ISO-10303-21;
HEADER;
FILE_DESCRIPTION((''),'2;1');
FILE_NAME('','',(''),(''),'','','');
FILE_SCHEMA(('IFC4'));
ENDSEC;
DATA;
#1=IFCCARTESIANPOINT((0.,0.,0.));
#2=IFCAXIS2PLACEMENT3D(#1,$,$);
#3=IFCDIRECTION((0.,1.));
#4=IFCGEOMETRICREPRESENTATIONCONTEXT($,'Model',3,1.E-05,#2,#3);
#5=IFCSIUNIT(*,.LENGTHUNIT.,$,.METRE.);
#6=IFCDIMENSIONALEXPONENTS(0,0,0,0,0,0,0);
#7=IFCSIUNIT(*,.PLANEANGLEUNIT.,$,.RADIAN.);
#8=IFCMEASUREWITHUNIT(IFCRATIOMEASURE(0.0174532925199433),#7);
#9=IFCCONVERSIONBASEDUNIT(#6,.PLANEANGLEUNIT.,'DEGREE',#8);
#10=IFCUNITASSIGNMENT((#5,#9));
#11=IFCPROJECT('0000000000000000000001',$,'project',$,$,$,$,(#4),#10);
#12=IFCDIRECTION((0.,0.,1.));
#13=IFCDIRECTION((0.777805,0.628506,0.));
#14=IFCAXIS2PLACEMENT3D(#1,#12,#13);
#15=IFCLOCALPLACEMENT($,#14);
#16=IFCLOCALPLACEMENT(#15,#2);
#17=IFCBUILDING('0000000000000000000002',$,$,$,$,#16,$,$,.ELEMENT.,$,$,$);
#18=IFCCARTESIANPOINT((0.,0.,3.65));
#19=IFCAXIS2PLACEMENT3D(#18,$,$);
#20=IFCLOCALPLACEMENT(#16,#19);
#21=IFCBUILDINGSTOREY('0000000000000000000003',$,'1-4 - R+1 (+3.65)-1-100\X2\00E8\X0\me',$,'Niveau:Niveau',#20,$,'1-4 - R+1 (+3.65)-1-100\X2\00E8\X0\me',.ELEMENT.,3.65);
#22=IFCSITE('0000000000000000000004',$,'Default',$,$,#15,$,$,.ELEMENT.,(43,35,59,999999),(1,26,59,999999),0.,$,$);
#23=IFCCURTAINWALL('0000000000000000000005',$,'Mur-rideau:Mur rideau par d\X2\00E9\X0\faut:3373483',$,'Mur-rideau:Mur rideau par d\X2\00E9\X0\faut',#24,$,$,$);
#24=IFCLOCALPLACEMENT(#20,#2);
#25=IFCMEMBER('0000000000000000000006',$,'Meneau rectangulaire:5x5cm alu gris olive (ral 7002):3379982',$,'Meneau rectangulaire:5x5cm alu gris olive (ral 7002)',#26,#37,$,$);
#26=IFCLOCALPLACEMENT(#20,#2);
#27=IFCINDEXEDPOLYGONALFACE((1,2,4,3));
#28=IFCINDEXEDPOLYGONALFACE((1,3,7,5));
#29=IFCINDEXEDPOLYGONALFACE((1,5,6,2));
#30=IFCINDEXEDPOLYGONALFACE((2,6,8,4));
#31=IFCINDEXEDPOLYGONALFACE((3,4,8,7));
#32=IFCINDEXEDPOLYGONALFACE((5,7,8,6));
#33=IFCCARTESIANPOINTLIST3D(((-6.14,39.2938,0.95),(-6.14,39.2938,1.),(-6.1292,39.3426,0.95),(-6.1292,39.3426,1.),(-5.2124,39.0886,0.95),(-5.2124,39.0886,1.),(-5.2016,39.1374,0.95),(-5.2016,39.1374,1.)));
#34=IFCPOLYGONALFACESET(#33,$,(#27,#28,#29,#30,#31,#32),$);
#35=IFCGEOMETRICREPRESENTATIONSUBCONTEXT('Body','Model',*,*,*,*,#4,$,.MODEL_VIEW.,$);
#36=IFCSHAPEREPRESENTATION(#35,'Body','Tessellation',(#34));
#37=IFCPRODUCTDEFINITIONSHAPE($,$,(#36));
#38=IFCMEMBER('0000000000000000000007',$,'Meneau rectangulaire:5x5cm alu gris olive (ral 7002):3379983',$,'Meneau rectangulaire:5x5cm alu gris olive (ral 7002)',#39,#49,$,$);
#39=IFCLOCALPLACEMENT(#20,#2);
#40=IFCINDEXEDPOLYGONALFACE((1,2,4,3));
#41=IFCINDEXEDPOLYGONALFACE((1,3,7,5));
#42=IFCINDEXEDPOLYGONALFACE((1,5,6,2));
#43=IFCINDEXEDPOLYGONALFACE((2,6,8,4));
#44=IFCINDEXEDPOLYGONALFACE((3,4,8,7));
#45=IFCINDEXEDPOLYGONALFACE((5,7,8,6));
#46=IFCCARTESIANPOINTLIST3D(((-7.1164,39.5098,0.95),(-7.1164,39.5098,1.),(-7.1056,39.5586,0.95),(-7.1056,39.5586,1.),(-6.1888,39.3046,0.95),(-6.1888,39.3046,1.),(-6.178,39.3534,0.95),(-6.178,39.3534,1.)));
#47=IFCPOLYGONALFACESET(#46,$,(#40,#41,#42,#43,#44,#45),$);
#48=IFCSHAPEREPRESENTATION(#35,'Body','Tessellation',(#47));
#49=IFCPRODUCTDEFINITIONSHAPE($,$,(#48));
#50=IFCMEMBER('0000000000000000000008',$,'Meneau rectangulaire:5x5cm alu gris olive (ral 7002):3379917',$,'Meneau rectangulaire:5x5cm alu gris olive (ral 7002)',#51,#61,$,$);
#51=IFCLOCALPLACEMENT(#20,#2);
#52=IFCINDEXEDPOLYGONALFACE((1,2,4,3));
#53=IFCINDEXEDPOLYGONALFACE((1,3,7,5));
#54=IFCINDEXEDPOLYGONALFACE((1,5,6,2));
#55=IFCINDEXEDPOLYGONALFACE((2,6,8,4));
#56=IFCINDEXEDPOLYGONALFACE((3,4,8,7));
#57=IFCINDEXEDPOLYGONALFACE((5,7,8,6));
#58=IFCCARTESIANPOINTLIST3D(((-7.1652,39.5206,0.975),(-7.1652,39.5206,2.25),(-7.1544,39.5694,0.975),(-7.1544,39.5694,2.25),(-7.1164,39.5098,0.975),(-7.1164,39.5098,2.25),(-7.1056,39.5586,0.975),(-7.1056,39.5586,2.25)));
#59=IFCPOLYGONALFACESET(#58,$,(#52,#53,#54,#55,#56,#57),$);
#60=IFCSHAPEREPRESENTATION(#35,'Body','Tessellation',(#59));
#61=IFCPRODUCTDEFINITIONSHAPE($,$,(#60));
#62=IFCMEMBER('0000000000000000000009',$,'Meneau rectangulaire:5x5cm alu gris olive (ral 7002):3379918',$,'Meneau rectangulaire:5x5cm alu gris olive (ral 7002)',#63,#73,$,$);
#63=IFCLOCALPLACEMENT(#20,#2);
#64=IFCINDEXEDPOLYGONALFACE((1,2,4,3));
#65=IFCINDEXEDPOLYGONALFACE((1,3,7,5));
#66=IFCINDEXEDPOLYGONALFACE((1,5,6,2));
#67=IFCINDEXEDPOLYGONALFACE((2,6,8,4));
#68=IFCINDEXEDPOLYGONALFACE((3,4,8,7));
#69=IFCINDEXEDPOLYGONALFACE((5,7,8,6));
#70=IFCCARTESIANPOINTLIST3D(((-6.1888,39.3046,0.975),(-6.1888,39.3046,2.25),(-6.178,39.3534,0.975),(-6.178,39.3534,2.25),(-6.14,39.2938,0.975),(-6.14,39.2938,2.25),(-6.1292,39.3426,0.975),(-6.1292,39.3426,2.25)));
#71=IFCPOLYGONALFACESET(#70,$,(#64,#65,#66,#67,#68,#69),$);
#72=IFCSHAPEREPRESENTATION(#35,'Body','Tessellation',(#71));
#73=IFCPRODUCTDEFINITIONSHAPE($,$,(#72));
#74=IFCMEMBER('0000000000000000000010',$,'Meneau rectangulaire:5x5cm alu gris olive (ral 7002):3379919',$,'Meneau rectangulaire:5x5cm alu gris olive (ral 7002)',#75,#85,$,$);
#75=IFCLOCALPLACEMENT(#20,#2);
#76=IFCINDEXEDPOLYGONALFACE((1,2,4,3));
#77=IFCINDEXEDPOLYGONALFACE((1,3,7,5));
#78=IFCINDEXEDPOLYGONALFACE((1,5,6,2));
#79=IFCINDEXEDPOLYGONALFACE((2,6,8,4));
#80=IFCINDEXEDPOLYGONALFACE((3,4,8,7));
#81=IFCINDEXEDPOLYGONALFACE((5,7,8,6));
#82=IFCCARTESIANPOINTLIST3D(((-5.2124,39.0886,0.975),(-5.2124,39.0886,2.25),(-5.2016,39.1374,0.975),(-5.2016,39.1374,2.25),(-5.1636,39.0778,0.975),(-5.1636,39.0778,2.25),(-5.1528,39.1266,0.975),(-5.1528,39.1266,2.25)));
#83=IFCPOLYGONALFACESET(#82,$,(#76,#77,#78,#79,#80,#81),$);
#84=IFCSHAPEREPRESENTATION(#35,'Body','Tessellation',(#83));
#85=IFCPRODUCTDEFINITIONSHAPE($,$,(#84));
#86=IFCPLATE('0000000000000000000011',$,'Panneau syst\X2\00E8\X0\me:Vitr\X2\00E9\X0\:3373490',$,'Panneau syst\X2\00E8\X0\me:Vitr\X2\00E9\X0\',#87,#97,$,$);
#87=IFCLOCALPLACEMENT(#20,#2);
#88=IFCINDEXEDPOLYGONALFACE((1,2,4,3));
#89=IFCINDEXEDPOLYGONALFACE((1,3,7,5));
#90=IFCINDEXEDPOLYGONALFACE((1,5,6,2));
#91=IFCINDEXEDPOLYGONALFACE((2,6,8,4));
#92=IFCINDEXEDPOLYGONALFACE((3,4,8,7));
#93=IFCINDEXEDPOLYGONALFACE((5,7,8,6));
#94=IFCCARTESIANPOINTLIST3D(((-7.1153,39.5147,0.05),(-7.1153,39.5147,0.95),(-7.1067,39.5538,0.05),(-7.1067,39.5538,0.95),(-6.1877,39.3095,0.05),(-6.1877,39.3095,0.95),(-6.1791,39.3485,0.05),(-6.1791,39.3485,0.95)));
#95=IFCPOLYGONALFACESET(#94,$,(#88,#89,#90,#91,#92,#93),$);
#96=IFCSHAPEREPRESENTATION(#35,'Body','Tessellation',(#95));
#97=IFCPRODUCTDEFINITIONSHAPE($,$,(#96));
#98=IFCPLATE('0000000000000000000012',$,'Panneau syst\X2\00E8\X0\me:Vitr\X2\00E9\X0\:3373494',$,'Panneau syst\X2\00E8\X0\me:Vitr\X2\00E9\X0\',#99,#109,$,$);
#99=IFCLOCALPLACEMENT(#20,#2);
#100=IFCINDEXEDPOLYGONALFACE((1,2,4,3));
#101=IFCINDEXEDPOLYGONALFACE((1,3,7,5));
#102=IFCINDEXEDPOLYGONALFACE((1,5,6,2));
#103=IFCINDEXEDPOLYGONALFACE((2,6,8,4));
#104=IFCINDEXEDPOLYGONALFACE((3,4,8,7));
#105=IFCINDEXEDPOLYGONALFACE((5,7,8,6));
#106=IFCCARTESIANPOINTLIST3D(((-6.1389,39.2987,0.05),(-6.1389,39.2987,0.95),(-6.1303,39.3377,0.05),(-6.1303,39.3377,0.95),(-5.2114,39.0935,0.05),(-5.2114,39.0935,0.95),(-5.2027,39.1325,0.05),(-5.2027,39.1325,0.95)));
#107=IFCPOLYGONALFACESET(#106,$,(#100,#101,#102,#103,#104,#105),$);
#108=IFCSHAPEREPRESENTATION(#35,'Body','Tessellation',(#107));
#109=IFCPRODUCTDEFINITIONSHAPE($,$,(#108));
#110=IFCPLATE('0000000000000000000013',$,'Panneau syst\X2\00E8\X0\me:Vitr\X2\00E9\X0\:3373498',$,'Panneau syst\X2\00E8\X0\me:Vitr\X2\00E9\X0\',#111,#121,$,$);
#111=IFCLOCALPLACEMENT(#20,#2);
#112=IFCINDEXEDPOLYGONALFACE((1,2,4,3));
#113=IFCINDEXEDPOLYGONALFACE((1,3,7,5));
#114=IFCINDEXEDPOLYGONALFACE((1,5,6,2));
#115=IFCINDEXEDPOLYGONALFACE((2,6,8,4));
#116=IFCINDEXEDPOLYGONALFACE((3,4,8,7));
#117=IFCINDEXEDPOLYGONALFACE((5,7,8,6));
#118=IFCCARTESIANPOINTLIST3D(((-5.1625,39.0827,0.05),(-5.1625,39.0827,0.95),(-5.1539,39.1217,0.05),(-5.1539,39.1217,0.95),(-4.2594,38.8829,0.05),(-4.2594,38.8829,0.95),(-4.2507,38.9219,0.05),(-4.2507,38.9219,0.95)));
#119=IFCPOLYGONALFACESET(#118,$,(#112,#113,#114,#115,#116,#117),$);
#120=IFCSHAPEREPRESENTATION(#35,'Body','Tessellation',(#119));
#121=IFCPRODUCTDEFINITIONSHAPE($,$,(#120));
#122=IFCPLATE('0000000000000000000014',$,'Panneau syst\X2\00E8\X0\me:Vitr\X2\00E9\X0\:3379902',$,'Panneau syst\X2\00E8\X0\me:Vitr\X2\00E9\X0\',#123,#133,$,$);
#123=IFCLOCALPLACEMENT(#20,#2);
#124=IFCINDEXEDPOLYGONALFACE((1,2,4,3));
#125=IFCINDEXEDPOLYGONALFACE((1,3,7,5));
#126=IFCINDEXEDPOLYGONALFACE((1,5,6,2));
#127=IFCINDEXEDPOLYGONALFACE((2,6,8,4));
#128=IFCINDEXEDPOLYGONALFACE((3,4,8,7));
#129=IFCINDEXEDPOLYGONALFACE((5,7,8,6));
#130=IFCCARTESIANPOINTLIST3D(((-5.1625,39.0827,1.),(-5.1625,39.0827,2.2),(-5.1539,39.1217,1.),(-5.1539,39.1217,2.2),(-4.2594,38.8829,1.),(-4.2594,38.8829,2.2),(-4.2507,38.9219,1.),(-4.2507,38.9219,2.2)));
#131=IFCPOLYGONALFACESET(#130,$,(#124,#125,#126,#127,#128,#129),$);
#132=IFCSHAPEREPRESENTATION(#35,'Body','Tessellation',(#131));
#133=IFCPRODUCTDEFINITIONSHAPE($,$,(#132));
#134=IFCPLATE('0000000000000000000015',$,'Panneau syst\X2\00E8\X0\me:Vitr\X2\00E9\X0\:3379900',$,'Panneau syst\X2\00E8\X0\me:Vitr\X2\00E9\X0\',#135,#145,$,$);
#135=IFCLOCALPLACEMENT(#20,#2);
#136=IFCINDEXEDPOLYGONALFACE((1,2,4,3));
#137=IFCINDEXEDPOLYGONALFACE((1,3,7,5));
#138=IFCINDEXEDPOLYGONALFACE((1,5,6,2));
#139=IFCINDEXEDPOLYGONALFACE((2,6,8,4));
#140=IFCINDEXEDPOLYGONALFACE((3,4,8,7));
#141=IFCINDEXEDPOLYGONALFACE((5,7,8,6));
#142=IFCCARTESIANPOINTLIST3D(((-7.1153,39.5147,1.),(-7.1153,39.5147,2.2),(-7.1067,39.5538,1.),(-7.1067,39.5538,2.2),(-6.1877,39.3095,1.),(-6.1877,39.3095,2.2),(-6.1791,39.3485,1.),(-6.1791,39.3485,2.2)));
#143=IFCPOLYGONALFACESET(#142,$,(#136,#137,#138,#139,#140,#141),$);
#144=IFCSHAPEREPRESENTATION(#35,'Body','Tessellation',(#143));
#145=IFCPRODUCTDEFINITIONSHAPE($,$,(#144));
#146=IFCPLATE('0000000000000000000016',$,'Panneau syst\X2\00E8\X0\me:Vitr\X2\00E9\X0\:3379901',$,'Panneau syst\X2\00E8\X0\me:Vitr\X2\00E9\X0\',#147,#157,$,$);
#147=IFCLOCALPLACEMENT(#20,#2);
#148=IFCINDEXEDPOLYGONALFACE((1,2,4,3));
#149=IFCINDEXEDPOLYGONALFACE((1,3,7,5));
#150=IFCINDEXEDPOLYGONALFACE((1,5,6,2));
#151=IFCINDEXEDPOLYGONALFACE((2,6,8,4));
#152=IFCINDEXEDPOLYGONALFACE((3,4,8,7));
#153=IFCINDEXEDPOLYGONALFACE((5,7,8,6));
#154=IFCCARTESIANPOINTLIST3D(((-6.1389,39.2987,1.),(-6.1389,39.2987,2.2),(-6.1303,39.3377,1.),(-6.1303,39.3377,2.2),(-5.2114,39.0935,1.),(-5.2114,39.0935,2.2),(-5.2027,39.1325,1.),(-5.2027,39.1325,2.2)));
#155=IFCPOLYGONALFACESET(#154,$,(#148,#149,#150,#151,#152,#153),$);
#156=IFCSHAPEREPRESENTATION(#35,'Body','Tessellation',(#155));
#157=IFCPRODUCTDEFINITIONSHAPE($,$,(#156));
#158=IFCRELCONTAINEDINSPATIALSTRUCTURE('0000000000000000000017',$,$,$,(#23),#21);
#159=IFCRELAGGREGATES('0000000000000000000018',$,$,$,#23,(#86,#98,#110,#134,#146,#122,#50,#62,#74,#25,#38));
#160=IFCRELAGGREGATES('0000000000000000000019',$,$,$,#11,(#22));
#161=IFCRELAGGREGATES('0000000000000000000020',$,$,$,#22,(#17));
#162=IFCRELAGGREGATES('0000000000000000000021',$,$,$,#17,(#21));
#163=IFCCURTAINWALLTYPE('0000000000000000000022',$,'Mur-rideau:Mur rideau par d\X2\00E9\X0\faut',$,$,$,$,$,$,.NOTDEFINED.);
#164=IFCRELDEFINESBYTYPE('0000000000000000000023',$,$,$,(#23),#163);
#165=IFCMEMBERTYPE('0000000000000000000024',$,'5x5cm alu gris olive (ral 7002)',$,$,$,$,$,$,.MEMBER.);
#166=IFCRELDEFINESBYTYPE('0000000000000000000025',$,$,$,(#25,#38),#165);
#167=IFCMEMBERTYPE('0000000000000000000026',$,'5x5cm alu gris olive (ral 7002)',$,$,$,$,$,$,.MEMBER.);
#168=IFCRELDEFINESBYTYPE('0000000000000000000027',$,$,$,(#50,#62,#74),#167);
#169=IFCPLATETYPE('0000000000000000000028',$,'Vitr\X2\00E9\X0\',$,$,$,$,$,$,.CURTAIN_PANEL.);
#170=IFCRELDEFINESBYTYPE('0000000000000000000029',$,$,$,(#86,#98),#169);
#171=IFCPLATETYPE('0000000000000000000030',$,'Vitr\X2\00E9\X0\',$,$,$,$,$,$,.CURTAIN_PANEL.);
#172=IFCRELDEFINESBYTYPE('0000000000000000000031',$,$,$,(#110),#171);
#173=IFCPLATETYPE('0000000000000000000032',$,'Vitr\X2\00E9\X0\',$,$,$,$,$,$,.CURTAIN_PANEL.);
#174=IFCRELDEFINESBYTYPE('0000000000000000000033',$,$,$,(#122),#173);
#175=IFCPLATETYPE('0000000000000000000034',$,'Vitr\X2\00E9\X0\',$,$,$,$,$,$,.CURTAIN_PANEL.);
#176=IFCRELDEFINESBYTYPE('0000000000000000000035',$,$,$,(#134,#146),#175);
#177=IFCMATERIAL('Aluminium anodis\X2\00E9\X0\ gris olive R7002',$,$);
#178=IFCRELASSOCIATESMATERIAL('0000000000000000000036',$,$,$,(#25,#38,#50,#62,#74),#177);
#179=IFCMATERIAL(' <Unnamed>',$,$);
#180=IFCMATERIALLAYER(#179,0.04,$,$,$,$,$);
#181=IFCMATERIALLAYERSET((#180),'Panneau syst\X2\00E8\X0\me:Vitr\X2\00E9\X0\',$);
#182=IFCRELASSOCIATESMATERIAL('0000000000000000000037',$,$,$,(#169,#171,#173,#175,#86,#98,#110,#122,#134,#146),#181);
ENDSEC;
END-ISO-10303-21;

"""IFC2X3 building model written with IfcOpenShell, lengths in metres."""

from ifc_helpers import new_model, entity, si_unit, converted_unit, direction, frame, frame_2d, origin, origin_2d_with_axis, place, context, subcontext, project, spatial, rectangle, extrude, source, transform, mapped, material, layer, layer_set, layer_usage, type_object, type_shapes, element, aggregate, save


model = new_model("IFC2X3")

# Units and contexts
model_context = context("Model", 3, precision=1e-05, world=origin(), true_north=direction((0.0, 1.0)))
body_context = subcontext(model_context, "Body", "Model", "MODEL_VIEW")
ifc_project = project(units=[si_unit("LENGTHUNIT", "METRE"), converted_unit("PLANEANGLEUNIT", "DEGREE", entity("IfcRatioMeasure", 0.0174532925199433), si_unit("PLANEANGLEUNIT", "RADIAN"), dimensions=[0, 0, 0, 0, 0, 0, 0])], contexts=[model_context])

# Site, building, storey
site_placement = place(None, frame((0.0, 0.0, 0.0), z_axis=(0.0, 0.0, 1.0), x_axis=(0.777805, 0.628506, 0.0)))
site = spatial("IfcSite", under=ifc_project, at=site_placement, Name="Default", CompositionType="ELEMENT", RefLatitude=(43, 35, 59, 999999), RefLongitude=(1, 26, 59, 999999), RefElevation=0.0)
building_placement = place(site_placement, origin())
building = spatial("IfcBuilding", under=site, at=building_placement, CompositionType="ELEMENT")
storey_placement = place(building_placement, frame((0.0, 0.0, 3.65)))
storey = spatial("IfcBuildingStorey", under=building, at=storey_placement, Name="1-4 - R+1 (+3.65)-1-100ème", ObjectType="Niveau:Niveau", LongName="1-4 - R+1 (+3.65)-1-100ème", CompositionType="ELEMENT", Elevation=3.65)

# Curtain wall, members, plates
curtain_wall_type = type_object("IfcCurtainWallType", Name="Mur-rideau:Mur rideau par défaut", PredefinedType="NOTDEFINED")
curtain_wall_placement = place(storey_placement, frame((0.0, 0.0, -3.65)))
curtain_wall = element("IfcCurtainWall", 1, at=curtain_wall_placement, inside=storey, type_object=curtain_wall_type, Name="Mur-rideau:Mur rideau par défaut:3373483", ObjectType="Mur-rideau:Mur rideau par défaut")
ifc_material_1 = material(Name="Aluminium anodisé gris olive R7002")
member_type_1 = type_object("IfcMemberType", Name="5x5cm alu gris olive (ral 7002)", PredefinedType="MEMBER")
shared_shape_1 = source(origin(), body_context, "Body", "SweptSolid", [
    extrude(rectangle(XDim=0.05, YDim=0.05, at=origin_2d_with_axis()), frame((0.0, 0.0, -0.95), z_axis=(0.0, 0.0, 1.0), x_axis=(0.0, -1.0, 0.0)), (0.0, 0.0, 1.0), 0.95),
])
type_shapes(member_type_1, [shared_shape_1])
member_1_placement = place(storey_placement, frame((-5.207, 39.113, 0.975), z_axis=(0.976392, -0.216005, 0.0), x_axis=(0.0, 0.0, 1.0)))
member_1 = element("IfcMember", 2, at=member_1_placement, type_object=member_type_1, material=ifc_material_1, Name="Meneau rectangulaire:5x5cm alu gris olive (ral 7002):3379982", ObjectType="Meneau rectangulaire:5x5cm alu gris olive (ral 7002)", context=body_context, shape_type="MappedRepresentation", body=[
    mapped(shared_shape_1, transform((0.0, 0.0, 0.0), scale=1.0)),
])
member_2_placement = place(storey_placement, frame((-6.1834, 39.329, 0.975), z_axis=(0.976392, -0.216005, 0.0), x_axis=(0.0, 0.0, 1.0)))
member_2 = element("IfcMember", 3, at=member_2_placement, type_object=member_type_1, material=ifc_material_1, Name="Meneau rectangulaire:5x5cm alu gris olive (ral 7002):3379983", ObjectType="Meneau rectangulaire:5x5cm alu gris olive (ral 7002)", context=body_context, shape_type="MappedRepresentation", body=[
    mapped(shared_shape_1, transform((0.0, 0.0, 0.0), scale=1.0)),
])
member_type_2 = type_object("IfcMemberType", Name="5x5cm alu gris olive (ral 7002)", PredefinedType="MEMBER")
shared_shape_2 = source(origin(), body_context, "Body", "SweptSolid", [
    extrude(rectangle(XDim=0.05, YDim=0.05, at=origin_2d_with_axis()), frame((0.0, 0.0, -1.275), z_axis=(0.0, 0.0, 1.0), x_axis=(0.0, -1.0, 0.0)), (0.0, 0.0, 1.0), 1.275),
])
type_shapes(member_type_2, [shared_shape_2])
member_3_placement = place(storey_placement, frame((-7.1354, 39.5396, 0.975), z_axis=(0.0, 0.0, -1.0), x_axis=(0.976392, -0.216005, 0.0)))
member_3 = element("IfcMember", 4, at=member_3_placement, type_object=member_type_2, material=ifc_material_1, Name="Meneau rectangulaire:5x5cm alu gris olive (ral 7002):3379917", ObjectType="Meneau rectangulaire:5x5cm alu gris olive (ral 7002)", context=body_context, shape_type="MappedRepresentation", body=[
    mapped(shared_shape_2, transform((0.0, 0.0, 0.0), scale=1.0)),
])
member_4_placement = place(storey_placement, frame((-6.159, 39.3236, 0.975), z_axis=(0.0, 0.0, -1.0), x_axis=(0.976392, -0.216005, 0.0)))
member_4 = element("IfcMember", 5, at=member_4_placement, type_object=member_type_2, material=ifc_material_1, Name="Meneau rectangulaire:5x5cm alu gris olive (ral 7002):3379918", ObjectType="Meneau rectangulaire:5x5cm alu gris olive (ral 7002)", context=body_context, shape_type="MappedRepresentation", body=[
    mapped(shared_shape_2, transform((0.0, 0.0, 0.0), scale=1.0)),
])
member_5_placement = place(storey_placement, frame((-5.1826, 39.1076, 0.975), z_axis=(0.0, 0.0, -1.0), x_axis=(0.976392, -0.216005, 0.0)))
member_5 = element("IfcMember", 6, at=member_5_placement, type_object=member_type_2, material=ifc_material_1, Name="Meneau rectangulaire:5x5cm alu gris olive (ral 7002):3379919", ObjectType="Meneau rectangulaire:5x5cm alu gris olive (ral 7002)", context=body_context, shape_type="MappedRepresentation", body=[
    mapped(shared_shape_2, transform((0.0, 0.0, 0.0), scale=1.0)),
])
ifc_material_2 = material(Name=" <Unnamed>")
ifc_layer = layer(ifc_material_2, 0.04)
ifc_layer_set = layer_set([ifc_layer], Name="Panneau système:Vitré")
ifc_layer_usage_1 = layer_usage(ifc_layer_set, "AXIS3", "POSITIVE", 0.0)
plate_type_1 = type_object("IfcPlateType", Name="Vitré", PredefinedType="CURTAIN_PANEL", material=ifc_layer_set)
shared_shape_3 = source(origin(), body_context, "Body", "SweptSolid", [
    extrude(rectangle(XDim=0.04, YDim=0.95, at=frame_2d((0.0, 0.0), x_axis=(1.0, 0.0))), frame((0.0, 0.0, 0.0), z_axis=(0.0, 0.0, 1.0), x_axis=(0.0, 1.0, 0.0)), (0.0, 0.0, 1.0), 0.9),
])
type_shapes(plate_type_1, [shared_shape_3])
plate_1_placement = place(curtain_wall_placement, frame((-6.6472, 39.4316, 3.7), z_axis=(0.0, 0.0, 1.0), x_axis=(0.976392, -0.216005, 0.0)))
plate_1 = element("IfcPlate", 7, at=plate_1_placement, type_object=plate_type_1, material=ifc_layer_usage_1, Name="Panneau système:Vitré:3373490", ObjectType="Panneau système:Vitré", context=body_context, shape_type="MappedRepresentation", body=[
    mapped(shared_shape_3, transform((0.0, 0.0, 0.0), scale=1.0)),
])
ifc_layer_usage_2 = layer_usage(ifc_layer_set, "AXIS3", "POSITIVE", 0.0)
plate_2_placement = place(curtain_wall_placement, frame((-5.6708, 39.2156, 3.7), z_axis=(0.0, 0.0, 1.0), x_axis=(0.976392, -0.216005, 0.0)))
plate_2 = element("IfcPlate", 8, at=plate_2_placement, type_object=plate_type_1, material=ifc_layer_usage_2, Name="Panneau système:Vitré:3373494", ObjectType="Panneau système:Vitré", context=body_context, shape_type="MappedRepresentation", body=[
    mapped(shared_shape_3, transform((0.0, 0.0, 0.0), scale=1.0)),
])
ifc_layer_usage_3 = layer_usage(ifc_layer_set, "AXIS3", "POSITIVE", 0.0)
plate_type_2 = type_object("IfcPlateType", Name="Vitré", PredefinedType="CURTAIN_PANEL", material=ifc_layer_set)
shared_shape_4 = source(origin(), body_context, "Body", "SweptSolid", [
    extrude(rectangle(XDim=0.04, YDim=0.925, at=frame_2d((0.0, 0.0), x_axis=(1.0, 0.0))), frame((0.0, 0.0, 0.0), z_axis=(0.0, 0.0, 1.0), x_axis=(0.0, 1.0, 0.0)), (0.0, 0.0, 1.0), 0.9),
])
type_shapes(plate_type_2, [shared_shape_4])
plate_3_placement = place(curtain_wall_placement, frame((-4.7066, 39.0023, 3.7), z_axis=(0.0, 0.0, 1.0), x_axis=(0.976392, -0.216005, 0.0)))
plate_3 = element("IfcPlate", 9, at=plate_3_placement, type_object=plate_type_2, material=ifc_layer_usage_3, Name="Panneau système:Vitré:3373498", ObjectType="Panneau système:Vitré", context=body_context, shape_type="MappedRepresentation", body=[
    mapped(shared_shape_4, transform((0.0, 0.0, 0.0), scale=1.0)),
])
ifc_layer_usage_4 = layer_usage(ifc_layer_set, "AXIS3", "POSITIVE", 0.0)
plate_type_3 = type_object("IfcPlateType", Name="Vitré", PredefinedType="CURTAIN_PANEL", material=ifc_layer_set)
shared_shape_5 = source(origin(), body_context, "Body", "SweptSolid", [
    extrude(rectangle(XDim=0.04, YDim=0.925, at=frame_2d((0.0, 0.0), x_axis=(1.0, 0.0))), frame((0.0, 0.0, 0.0), z_axis=(0.0, 0.0, 1.0), x_axis=(0.0, 1.0, 0.0)), (0.0, 0.0, 1.0), 1.2),
])
type_shapes(plate_type_3, [shared_shape_5])
plate_4_placement = place(curtain_wall_placement, frame((-4.7066, 39.0023, 4.65), z_axis=(0.0, 0.0, 1.0), x_axis=(0.976392, -0.216005, 0.0)))
plate_4 = element("IfcPlate", 10, at=plate_4_placement, type_object=plate_type_3, material=ifc_layer_usage_4, Name="Panneau système:Vitré:3379902", ObjectType="Panneau système:Vitré", context=body_context, shape_type="MappedRepresentation", body=[
    mapped(shared_shape_5, transform((0.0, 0.0, 0.0), scale=1.0)),
])
ifc_layer_usage_5 = layer_usage(ifc_layer_set, "AXIS3", "POSITIVE", 0.0)
plate_type_4 = type_object("IfcPlateType", Name="Vitré", PredefinedType="CURTAIN_PANEL", material=ifc_layer_set)
shared_shape_6 = source(origin(), body_context, "Body", "SweptSolid", [
    extrude(rectangle(XDim=0.04, YDim=0.95, at=frame_2d((0.0, 0.0), x_axis=(1.0, 0.0))), frame((0.0, 0.0, 0.0), z_axis=(0.0, 0.0, 1.0), x_axis=(0.0, 1.0, 0.0)), (0.0, 0.0, 1.0), 1.2),
])
type_shapes(plate_type_4, [shared_shape_6])
plate_5_placement = place(curtain_wall_placement, frame((-6.6472, 39.4316, 4.65), z_axis=(0.0, 0.0, 1.0), x_axis=(0.976392, -0.216005, 0.0)))
plate_5 = element("IfcPlate", 11, at=plate_5_placement, type_object=plate_type_4, material=ifc_layer_usage_5, Name="Panneau système:Vitré:3379900", ObjectType="Panneau système:Vitré", context=body_context, shape_type="MappedRepresentation", body=[
    mapped(shared_shape_6, transform((0.0, 0.0, 0.0), scale=1.0)),
])
ifc_layer_usage_6 = layer_usage(ifc_layer_set, "AXIS3", "POSITIVE", 0.0)
plate_6_placement = place(curtain_wall_placement, frame((-5.6708, 39.2156, 4.65), z_axis=(0.0, 0.0, 1.0), x_axis=(0.976392, -0.216005, 0.0)))
plate_6 = element("IfcPlate", 12, at=plate_6_placement, type_object=plate_type_4, material=ifc_layer_usage_6, Name="Panneau système:Vitré:3379901", ObjectType="Panneau système:Vitré", context=body_context, shape_type="MappedRepresentation", body=[
    mapped(shared_shape_6, transform((0.0, 0.0, 0.0), scale=1.0)),
])
aggregate(curtain_wall, [plate_1, plate_2, plate_3, plate_5, plate_6, plate_4, member_3, member_4, member_5, member_1, member_2])

save(model, "model.ifc")
